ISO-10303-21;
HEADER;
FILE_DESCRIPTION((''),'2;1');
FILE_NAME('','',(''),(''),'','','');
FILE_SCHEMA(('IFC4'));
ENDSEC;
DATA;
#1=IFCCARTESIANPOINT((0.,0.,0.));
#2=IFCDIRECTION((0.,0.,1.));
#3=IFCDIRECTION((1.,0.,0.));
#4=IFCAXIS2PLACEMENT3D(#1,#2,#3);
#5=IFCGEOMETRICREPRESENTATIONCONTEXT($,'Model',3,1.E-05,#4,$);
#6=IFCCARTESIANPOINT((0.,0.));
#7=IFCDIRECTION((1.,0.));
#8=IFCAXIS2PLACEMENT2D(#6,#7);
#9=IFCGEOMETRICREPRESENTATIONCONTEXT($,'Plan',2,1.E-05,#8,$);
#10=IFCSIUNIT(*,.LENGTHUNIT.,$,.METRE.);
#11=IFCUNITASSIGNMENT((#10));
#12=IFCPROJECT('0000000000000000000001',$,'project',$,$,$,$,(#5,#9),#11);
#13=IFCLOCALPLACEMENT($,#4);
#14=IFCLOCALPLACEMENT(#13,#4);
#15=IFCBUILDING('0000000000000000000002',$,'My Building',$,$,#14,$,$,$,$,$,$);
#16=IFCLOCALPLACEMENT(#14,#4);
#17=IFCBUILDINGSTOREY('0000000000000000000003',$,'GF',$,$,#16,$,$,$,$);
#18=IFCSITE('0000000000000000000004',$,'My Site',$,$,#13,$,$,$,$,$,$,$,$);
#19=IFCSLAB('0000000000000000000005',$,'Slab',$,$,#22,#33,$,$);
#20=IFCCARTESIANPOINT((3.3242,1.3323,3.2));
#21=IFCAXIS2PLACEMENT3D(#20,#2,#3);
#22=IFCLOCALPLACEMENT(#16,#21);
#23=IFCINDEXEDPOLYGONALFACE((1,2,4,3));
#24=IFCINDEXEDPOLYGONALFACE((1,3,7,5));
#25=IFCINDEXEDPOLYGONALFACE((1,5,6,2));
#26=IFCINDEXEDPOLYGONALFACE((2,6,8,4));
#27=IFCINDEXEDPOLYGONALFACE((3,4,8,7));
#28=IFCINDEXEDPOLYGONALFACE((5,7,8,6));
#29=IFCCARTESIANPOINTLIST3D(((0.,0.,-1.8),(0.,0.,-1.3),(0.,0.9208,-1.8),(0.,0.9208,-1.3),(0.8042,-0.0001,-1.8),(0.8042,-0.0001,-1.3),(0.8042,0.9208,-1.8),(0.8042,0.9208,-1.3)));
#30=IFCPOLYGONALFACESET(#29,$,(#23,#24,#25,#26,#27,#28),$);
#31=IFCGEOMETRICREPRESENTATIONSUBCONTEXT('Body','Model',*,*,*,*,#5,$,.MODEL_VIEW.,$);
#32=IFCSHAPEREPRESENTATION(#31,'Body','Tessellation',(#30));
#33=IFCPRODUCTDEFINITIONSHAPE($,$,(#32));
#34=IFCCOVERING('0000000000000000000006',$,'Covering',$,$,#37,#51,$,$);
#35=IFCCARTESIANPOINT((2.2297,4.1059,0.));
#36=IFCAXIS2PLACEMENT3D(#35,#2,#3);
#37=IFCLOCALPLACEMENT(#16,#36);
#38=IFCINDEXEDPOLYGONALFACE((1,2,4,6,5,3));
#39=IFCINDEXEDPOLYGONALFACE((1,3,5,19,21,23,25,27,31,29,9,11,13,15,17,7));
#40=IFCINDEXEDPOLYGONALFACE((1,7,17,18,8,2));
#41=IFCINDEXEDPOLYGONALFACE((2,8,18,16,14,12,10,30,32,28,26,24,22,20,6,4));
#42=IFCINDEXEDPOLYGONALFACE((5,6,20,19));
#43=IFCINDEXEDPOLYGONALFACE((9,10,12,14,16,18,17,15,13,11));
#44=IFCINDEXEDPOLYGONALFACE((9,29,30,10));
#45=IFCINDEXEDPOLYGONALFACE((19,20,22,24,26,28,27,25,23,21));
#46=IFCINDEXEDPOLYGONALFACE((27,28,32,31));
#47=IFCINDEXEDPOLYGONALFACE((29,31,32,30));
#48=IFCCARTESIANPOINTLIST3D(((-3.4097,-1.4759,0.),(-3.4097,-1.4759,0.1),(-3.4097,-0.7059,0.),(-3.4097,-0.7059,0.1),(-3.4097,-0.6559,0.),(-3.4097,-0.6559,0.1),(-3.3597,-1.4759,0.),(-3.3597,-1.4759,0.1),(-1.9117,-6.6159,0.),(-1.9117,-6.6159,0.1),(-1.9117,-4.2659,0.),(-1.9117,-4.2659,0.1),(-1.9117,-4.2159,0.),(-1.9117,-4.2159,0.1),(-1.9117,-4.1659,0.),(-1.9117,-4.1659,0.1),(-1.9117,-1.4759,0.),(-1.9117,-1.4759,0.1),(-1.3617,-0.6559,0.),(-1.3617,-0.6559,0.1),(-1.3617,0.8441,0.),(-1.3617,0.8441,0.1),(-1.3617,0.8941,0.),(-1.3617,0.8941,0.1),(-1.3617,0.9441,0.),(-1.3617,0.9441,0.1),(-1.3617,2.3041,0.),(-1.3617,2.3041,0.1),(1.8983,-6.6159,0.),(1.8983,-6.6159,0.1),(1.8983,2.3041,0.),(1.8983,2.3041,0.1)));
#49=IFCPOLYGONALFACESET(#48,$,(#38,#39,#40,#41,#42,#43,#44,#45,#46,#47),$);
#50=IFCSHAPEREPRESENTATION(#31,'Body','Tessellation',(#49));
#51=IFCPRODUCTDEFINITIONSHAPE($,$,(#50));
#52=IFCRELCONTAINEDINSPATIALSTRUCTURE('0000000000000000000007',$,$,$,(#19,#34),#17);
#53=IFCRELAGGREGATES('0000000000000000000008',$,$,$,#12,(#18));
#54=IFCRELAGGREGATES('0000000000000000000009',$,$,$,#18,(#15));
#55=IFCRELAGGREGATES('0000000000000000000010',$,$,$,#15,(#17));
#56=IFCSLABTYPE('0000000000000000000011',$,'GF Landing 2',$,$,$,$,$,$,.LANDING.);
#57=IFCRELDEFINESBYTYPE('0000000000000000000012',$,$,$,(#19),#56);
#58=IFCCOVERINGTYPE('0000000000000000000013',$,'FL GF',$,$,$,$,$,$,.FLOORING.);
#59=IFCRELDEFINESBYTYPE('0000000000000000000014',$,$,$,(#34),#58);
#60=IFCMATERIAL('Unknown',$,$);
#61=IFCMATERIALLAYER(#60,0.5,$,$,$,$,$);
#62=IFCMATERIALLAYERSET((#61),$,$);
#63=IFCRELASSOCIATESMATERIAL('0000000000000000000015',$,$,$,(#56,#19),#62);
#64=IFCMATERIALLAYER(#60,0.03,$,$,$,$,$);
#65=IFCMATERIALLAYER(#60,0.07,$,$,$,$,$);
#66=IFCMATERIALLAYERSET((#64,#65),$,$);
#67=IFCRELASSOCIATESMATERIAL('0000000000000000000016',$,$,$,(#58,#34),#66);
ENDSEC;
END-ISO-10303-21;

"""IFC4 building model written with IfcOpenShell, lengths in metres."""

from ifc_helpers import new_model, si_unit, frame, origin_with_axes, origin_2d_with_axis, place, context, subcontext, project, spatial, line, indexed_curve, outline, extrude, material, layer, layer_set, layer_usage, type_object, element, save


model = new_model("IFC4")

# Units and contexts
model_context = context("Model", 3, precision=1e-05, world=origin_with_axes())
plan_context = context("Plan", 2, precision=1e-05, world=origin_2d_with_axis())
body_context_1 = subcontext(model_context, "Body", "Model", "MODEL_VIEW")
ifc_project = project(units=[si_unit("LENGTHUNIT", "METRE")], contexts=[model_context, plan_context])

# Site, building, storey
site_placement = place(None, origin_with_axes())
site = spatial("IfcSite", under=ifc_project, at=site_placement, Name="My Site")
building_placement = place(site_placement, origin_with_axes())
building = spatial("IfcBuilding", under=site, at=building_placement, Name="My Building")
storey_placement = place(building_placement, origin_with_axes())
storey = spatial("IfcBuildingStorey", under=building, at=storey_placement, Name="GF")

# Slab
ifc_material = material(Name="Unknown")
ifc_layer_1 = layer(ifc_material, 0.5)
ifc_layer_set_1 = layer_set([ifc_layer_1])
ifc_layer_usage_1 = layer_usage(ifc_layer_set_1, "AXIS3", "POSITIVE", -1.8)
slab_type_1 = type_object("IfcSlabType", Name="GF Landing 2", PredefinedType="LANDING", material=ifc_layer_set_1)
slab_1_placement = place(storey_placement, frame((3.3242, 1.3323, 3.2), z_axis=(0.0, 0.0, 1.0), x_axis=(1.0, 0.0, 0.0)))
element("IfcSlab", 1, at=slab_1_placement, inside=storey, type_object=slab_type_1, material=ifc_layer_usage_1, Name="Slab", context=body_context_1, shape_type="SweptSolid", body=[
    extrude(outline(indexed_curve([(0.0, 0.0), (0.0, 0.9208), (0.8042, 0.9208), (0.8042, -0.0001), (0.0, 0.0)])), frame((0.0, 0.0, -1.8), z_axis=(0.0, 0.0, 1.0), x_axis=(1.0, 0.0, 0.0)), (0.0, 0.0, 1.0), 0.5),
])

# Covering
ifc_layer_2 = layer(ifc_material, 0.03)
ifc_layer_3 = layer(ifc_material, 0.07)
ifc_layer_set_2 = layer_set([ifc_layer_2, ifc_layer_3])
ifc_layer_usage_2 = layer_usage(ifc_layer_set_2, "AXIS3", "POSITIVE", 0.0)
covering_type = type_object("IfcCoveringType", Name="FL GF", PredefinedType="FLOORING", material=ifc_layer_set_2)
covering_placement = place(storey_placement, frame((2.2297, 4.1059, 0.0), z_axis=(0.0, 0.0, 1.0), x_axis=(1.0, 0.0, 0.0)))
element("IfcCovering", 2, at=covering_placement, inside=storey, type_object=covering_type, material=ifc_layer_usage_2, Name="Covering", context=body_context_1, shape_type="SweptSolid", body=[
    extrude(outline(indexed_curve([(-1.3617, 2.3041), (1.8983, 2.3041), (1.8983, -6.6159), (-1.9117, -6.6159), (-1.9117, -6.6159), (-1.9117, -4.2659), (-1.9117, -4.2159), (-1.9117, -4.2159), (-1.9117, -4.1659), (-1.9117, -1.4759), (-3.3597, -1.4759), (-3.4097, -1.4759), (-3.4097, -0.7059), (-3.4097, -0.6559), (-1.3617, -0.6559), (-1.3617, 0.8441), (-1.3617, 0.8941), (-1.3617, 0.9441)], segments=[line(1, 2, 3, 4, 5, 6, 7, 8, 9, 10, 11, 12, 13, 14, 15, 16, 17, 18, 1)])), origin_with_axes(), (0.0, 0.0, 1.0), 0.1),
])

save(model, "model.ifc")
